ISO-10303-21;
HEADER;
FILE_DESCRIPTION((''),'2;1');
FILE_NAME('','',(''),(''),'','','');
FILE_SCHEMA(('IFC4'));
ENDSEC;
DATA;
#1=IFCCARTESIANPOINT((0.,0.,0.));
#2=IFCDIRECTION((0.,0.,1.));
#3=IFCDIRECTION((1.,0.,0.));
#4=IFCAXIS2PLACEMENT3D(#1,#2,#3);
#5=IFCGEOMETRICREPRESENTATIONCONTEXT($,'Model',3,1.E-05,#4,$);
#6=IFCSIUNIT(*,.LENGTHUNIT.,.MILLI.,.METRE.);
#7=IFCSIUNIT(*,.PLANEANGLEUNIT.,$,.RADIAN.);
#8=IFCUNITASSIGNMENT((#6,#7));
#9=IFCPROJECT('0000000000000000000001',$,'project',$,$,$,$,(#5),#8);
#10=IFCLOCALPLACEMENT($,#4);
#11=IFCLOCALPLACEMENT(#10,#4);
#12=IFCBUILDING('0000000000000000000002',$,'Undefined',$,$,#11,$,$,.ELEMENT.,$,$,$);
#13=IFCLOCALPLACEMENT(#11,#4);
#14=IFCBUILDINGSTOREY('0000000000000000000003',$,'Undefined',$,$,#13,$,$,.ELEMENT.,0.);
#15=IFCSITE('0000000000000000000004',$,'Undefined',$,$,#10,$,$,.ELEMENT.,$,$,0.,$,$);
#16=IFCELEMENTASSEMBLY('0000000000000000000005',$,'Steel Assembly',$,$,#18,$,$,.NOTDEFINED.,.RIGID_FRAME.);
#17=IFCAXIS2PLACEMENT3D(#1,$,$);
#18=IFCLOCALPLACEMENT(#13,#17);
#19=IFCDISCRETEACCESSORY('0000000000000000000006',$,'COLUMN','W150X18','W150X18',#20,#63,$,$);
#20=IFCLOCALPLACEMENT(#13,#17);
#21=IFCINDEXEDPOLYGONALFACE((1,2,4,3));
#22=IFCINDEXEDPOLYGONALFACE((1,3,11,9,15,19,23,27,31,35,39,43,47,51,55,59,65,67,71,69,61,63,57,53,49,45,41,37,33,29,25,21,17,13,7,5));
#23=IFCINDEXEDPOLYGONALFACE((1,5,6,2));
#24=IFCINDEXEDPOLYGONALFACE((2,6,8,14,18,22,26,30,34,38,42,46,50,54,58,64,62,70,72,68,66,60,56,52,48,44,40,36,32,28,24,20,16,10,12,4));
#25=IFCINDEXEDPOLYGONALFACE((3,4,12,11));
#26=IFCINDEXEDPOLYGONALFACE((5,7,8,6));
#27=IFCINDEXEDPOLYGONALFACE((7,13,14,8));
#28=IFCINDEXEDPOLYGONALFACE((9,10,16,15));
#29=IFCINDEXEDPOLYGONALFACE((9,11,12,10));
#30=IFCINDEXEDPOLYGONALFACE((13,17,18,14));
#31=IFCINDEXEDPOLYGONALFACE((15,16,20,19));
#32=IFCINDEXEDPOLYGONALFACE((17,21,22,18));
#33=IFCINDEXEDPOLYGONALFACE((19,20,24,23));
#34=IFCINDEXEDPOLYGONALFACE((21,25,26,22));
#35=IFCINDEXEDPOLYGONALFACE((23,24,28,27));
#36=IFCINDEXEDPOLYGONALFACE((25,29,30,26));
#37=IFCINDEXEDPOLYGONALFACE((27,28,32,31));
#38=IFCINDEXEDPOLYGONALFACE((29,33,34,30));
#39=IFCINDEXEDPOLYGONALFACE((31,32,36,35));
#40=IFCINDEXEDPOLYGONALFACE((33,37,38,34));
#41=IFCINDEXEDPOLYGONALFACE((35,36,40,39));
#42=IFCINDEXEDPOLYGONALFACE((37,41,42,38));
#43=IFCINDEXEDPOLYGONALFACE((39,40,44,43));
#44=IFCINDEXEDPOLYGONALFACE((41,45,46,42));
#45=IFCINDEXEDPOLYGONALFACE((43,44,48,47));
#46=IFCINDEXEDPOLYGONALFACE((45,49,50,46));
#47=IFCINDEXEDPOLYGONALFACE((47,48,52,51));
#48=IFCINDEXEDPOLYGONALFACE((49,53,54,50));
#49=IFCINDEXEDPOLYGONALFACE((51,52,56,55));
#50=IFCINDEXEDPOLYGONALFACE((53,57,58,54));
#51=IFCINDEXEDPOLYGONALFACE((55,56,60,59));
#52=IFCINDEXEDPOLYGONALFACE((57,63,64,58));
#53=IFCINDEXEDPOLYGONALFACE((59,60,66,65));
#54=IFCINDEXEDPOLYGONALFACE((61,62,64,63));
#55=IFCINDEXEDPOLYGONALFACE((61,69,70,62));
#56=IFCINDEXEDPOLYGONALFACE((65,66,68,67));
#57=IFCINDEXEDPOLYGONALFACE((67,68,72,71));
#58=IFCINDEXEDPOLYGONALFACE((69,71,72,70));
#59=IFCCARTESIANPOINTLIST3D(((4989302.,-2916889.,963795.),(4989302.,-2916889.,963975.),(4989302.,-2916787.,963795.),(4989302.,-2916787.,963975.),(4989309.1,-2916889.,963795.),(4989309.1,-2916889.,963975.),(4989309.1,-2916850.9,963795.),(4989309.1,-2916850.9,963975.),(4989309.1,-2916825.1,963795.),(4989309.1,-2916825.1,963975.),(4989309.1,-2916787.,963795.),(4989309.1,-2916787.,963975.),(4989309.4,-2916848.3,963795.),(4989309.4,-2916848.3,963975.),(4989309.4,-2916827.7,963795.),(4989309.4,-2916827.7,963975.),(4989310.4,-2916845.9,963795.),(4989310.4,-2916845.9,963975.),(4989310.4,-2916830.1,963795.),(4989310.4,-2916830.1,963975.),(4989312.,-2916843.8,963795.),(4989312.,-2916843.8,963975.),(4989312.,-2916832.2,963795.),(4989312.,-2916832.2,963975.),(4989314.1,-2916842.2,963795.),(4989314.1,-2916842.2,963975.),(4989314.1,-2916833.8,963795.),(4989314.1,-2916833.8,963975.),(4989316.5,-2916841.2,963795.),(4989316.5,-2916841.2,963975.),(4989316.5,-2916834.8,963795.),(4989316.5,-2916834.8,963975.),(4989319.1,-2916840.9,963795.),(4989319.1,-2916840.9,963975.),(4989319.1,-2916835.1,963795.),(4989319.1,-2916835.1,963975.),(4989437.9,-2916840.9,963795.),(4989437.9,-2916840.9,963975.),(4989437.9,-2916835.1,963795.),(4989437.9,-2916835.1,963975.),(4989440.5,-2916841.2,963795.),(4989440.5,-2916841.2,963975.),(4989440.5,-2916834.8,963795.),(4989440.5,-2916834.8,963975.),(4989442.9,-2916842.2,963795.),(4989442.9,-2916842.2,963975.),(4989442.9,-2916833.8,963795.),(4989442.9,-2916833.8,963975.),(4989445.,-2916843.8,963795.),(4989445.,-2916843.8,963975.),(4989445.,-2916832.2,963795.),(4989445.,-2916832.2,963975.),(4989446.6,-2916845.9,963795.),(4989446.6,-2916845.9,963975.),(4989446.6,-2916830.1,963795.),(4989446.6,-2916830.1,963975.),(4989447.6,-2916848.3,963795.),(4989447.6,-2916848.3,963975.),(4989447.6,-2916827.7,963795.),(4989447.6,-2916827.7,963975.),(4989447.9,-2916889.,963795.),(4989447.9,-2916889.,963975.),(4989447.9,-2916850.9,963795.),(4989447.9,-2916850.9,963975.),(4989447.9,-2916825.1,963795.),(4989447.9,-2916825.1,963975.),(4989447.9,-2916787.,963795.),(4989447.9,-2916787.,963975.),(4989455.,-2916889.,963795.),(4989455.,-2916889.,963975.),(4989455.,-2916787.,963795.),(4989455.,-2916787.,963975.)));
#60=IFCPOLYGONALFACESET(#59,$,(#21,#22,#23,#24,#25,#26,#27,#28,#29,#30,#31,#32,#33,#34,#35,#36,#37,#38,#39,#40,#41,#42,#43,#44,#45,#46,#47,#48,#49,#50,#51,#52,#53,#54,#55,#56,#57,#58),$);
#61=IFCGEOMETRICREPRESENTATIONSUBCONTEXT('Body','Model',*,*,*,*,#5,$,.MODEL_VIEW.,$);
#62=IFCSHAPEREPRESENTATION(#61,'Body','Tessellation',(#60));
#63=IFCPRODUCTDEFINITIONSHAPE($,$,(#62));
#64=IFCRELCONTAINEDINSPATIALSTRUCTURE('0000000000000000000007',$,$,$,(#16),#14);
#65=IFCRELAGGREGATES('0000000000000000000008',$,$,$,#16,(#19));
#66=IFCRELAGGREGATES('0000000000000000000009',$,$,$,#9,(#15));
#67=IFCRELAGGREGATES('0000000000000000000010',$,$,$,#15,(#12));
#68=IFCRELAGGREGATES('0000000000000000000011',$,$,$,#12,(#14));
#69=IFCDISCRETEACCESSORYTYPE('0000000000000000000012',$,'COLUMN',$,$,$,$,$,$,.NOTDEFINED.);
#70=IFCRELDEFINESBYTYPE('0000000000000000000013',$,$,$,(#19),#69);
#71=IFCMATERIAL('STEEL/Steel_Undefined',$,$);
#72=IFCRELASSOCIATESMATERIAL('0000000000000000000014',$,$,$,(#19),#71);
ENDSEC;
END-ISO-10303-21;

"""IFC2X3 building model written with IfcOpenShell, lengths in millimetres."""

from ifc_helpers import new_model, si_unit, frame, origin_with_axes, origin_2d_with_axis, place, context, subcontext, project, spatial, i_section, extrude, material, type_object, element, aggregate, save


model = new_model("IFC2X3")

# Units and contexts
model_context = context("Model", 3, precision=1e-05, world=origin_with_axes())
body_context = subcontext(model_context, "Body", "Model", "MODEL_VIEW")
ifc_project = project(units=[si_unit("LENGTHUNIT", "METRE", prefix="MILLI"), si_unit("PLANEANGLEUNIT", "RADIAN")], contexts=[model_context])

# Site, building, storey
site_placement = place(None, origin_with_axes())
site = spatial("IfcSite", under=ifc_project, at=site_placement, Name="Undefined", CompositionType="ELEMENT", RefElevation=0.0)
building_placement = place(site_placement, origin_with_axes())
building = spatial("IfcBuilding", under=site, at=building_placement, Name="Undefined", CompositionType="ELEMENT")
storey_placement = place(building_placement, origin_with_axes())
storey = spatial("IfcBuildingStorey", under=building, at=storey_placement, Name="Undefined", CompositionType="ELEMENT", Elevation=0.0)

# Element assembly
assembly_1_placement = place(storey_placement, origin_with_axes())
assembly_1 = element("IfcElementAssembly", 1, at=assembly_1_placement, inside=storey, Name="Steel Assembly", AssemblyPlace="NOTDEFINED", PredefinedType="RIGID_FRAME")

# Discrete accessory
ifc_material_1 = material(Name="STEEL/Steel_Undefined")
discrete_accessory_type_1 = type_object("IfcDiscreteAccessoryType", Name="COLUMN")
discrete_accessory_1_placement = place(assembly_1_placement, frame((4989378.5, -2916838.0, 963795.0), z_axis=(0.0, 0.0, 1.0), x_axis=(-1.0, 0.0, 0.0)))
discrete_accessory_1 = element("IfcDiscreteAccessory", 2, at=discrete_accessory_1_placement, type_object=discrete_accessory_type_1, material=ifc_material_1, Name="COLUMN", Description="W150X18", ObjectType="W150X18", context=body_context, shape_type="SweptSolid", body=[
    extrude(i_section(OverallWidth=102.0, OverallDepth=153.0, WebThickness=5.8, FlangeThickness=7.1, FilletRadius=10.0, at=origin_2d_with_axis()), frame((0.0, 0.0, 180.0), z_axis=(0.0, 0.0, -1.0), x_axis=(0.0, 1.0, 0.0)), (0.0, 0.0, 1.0), 180.0),
])
aggregate(assembly_1, [discrete_accessory_1])

save(model, "model.ifc")
